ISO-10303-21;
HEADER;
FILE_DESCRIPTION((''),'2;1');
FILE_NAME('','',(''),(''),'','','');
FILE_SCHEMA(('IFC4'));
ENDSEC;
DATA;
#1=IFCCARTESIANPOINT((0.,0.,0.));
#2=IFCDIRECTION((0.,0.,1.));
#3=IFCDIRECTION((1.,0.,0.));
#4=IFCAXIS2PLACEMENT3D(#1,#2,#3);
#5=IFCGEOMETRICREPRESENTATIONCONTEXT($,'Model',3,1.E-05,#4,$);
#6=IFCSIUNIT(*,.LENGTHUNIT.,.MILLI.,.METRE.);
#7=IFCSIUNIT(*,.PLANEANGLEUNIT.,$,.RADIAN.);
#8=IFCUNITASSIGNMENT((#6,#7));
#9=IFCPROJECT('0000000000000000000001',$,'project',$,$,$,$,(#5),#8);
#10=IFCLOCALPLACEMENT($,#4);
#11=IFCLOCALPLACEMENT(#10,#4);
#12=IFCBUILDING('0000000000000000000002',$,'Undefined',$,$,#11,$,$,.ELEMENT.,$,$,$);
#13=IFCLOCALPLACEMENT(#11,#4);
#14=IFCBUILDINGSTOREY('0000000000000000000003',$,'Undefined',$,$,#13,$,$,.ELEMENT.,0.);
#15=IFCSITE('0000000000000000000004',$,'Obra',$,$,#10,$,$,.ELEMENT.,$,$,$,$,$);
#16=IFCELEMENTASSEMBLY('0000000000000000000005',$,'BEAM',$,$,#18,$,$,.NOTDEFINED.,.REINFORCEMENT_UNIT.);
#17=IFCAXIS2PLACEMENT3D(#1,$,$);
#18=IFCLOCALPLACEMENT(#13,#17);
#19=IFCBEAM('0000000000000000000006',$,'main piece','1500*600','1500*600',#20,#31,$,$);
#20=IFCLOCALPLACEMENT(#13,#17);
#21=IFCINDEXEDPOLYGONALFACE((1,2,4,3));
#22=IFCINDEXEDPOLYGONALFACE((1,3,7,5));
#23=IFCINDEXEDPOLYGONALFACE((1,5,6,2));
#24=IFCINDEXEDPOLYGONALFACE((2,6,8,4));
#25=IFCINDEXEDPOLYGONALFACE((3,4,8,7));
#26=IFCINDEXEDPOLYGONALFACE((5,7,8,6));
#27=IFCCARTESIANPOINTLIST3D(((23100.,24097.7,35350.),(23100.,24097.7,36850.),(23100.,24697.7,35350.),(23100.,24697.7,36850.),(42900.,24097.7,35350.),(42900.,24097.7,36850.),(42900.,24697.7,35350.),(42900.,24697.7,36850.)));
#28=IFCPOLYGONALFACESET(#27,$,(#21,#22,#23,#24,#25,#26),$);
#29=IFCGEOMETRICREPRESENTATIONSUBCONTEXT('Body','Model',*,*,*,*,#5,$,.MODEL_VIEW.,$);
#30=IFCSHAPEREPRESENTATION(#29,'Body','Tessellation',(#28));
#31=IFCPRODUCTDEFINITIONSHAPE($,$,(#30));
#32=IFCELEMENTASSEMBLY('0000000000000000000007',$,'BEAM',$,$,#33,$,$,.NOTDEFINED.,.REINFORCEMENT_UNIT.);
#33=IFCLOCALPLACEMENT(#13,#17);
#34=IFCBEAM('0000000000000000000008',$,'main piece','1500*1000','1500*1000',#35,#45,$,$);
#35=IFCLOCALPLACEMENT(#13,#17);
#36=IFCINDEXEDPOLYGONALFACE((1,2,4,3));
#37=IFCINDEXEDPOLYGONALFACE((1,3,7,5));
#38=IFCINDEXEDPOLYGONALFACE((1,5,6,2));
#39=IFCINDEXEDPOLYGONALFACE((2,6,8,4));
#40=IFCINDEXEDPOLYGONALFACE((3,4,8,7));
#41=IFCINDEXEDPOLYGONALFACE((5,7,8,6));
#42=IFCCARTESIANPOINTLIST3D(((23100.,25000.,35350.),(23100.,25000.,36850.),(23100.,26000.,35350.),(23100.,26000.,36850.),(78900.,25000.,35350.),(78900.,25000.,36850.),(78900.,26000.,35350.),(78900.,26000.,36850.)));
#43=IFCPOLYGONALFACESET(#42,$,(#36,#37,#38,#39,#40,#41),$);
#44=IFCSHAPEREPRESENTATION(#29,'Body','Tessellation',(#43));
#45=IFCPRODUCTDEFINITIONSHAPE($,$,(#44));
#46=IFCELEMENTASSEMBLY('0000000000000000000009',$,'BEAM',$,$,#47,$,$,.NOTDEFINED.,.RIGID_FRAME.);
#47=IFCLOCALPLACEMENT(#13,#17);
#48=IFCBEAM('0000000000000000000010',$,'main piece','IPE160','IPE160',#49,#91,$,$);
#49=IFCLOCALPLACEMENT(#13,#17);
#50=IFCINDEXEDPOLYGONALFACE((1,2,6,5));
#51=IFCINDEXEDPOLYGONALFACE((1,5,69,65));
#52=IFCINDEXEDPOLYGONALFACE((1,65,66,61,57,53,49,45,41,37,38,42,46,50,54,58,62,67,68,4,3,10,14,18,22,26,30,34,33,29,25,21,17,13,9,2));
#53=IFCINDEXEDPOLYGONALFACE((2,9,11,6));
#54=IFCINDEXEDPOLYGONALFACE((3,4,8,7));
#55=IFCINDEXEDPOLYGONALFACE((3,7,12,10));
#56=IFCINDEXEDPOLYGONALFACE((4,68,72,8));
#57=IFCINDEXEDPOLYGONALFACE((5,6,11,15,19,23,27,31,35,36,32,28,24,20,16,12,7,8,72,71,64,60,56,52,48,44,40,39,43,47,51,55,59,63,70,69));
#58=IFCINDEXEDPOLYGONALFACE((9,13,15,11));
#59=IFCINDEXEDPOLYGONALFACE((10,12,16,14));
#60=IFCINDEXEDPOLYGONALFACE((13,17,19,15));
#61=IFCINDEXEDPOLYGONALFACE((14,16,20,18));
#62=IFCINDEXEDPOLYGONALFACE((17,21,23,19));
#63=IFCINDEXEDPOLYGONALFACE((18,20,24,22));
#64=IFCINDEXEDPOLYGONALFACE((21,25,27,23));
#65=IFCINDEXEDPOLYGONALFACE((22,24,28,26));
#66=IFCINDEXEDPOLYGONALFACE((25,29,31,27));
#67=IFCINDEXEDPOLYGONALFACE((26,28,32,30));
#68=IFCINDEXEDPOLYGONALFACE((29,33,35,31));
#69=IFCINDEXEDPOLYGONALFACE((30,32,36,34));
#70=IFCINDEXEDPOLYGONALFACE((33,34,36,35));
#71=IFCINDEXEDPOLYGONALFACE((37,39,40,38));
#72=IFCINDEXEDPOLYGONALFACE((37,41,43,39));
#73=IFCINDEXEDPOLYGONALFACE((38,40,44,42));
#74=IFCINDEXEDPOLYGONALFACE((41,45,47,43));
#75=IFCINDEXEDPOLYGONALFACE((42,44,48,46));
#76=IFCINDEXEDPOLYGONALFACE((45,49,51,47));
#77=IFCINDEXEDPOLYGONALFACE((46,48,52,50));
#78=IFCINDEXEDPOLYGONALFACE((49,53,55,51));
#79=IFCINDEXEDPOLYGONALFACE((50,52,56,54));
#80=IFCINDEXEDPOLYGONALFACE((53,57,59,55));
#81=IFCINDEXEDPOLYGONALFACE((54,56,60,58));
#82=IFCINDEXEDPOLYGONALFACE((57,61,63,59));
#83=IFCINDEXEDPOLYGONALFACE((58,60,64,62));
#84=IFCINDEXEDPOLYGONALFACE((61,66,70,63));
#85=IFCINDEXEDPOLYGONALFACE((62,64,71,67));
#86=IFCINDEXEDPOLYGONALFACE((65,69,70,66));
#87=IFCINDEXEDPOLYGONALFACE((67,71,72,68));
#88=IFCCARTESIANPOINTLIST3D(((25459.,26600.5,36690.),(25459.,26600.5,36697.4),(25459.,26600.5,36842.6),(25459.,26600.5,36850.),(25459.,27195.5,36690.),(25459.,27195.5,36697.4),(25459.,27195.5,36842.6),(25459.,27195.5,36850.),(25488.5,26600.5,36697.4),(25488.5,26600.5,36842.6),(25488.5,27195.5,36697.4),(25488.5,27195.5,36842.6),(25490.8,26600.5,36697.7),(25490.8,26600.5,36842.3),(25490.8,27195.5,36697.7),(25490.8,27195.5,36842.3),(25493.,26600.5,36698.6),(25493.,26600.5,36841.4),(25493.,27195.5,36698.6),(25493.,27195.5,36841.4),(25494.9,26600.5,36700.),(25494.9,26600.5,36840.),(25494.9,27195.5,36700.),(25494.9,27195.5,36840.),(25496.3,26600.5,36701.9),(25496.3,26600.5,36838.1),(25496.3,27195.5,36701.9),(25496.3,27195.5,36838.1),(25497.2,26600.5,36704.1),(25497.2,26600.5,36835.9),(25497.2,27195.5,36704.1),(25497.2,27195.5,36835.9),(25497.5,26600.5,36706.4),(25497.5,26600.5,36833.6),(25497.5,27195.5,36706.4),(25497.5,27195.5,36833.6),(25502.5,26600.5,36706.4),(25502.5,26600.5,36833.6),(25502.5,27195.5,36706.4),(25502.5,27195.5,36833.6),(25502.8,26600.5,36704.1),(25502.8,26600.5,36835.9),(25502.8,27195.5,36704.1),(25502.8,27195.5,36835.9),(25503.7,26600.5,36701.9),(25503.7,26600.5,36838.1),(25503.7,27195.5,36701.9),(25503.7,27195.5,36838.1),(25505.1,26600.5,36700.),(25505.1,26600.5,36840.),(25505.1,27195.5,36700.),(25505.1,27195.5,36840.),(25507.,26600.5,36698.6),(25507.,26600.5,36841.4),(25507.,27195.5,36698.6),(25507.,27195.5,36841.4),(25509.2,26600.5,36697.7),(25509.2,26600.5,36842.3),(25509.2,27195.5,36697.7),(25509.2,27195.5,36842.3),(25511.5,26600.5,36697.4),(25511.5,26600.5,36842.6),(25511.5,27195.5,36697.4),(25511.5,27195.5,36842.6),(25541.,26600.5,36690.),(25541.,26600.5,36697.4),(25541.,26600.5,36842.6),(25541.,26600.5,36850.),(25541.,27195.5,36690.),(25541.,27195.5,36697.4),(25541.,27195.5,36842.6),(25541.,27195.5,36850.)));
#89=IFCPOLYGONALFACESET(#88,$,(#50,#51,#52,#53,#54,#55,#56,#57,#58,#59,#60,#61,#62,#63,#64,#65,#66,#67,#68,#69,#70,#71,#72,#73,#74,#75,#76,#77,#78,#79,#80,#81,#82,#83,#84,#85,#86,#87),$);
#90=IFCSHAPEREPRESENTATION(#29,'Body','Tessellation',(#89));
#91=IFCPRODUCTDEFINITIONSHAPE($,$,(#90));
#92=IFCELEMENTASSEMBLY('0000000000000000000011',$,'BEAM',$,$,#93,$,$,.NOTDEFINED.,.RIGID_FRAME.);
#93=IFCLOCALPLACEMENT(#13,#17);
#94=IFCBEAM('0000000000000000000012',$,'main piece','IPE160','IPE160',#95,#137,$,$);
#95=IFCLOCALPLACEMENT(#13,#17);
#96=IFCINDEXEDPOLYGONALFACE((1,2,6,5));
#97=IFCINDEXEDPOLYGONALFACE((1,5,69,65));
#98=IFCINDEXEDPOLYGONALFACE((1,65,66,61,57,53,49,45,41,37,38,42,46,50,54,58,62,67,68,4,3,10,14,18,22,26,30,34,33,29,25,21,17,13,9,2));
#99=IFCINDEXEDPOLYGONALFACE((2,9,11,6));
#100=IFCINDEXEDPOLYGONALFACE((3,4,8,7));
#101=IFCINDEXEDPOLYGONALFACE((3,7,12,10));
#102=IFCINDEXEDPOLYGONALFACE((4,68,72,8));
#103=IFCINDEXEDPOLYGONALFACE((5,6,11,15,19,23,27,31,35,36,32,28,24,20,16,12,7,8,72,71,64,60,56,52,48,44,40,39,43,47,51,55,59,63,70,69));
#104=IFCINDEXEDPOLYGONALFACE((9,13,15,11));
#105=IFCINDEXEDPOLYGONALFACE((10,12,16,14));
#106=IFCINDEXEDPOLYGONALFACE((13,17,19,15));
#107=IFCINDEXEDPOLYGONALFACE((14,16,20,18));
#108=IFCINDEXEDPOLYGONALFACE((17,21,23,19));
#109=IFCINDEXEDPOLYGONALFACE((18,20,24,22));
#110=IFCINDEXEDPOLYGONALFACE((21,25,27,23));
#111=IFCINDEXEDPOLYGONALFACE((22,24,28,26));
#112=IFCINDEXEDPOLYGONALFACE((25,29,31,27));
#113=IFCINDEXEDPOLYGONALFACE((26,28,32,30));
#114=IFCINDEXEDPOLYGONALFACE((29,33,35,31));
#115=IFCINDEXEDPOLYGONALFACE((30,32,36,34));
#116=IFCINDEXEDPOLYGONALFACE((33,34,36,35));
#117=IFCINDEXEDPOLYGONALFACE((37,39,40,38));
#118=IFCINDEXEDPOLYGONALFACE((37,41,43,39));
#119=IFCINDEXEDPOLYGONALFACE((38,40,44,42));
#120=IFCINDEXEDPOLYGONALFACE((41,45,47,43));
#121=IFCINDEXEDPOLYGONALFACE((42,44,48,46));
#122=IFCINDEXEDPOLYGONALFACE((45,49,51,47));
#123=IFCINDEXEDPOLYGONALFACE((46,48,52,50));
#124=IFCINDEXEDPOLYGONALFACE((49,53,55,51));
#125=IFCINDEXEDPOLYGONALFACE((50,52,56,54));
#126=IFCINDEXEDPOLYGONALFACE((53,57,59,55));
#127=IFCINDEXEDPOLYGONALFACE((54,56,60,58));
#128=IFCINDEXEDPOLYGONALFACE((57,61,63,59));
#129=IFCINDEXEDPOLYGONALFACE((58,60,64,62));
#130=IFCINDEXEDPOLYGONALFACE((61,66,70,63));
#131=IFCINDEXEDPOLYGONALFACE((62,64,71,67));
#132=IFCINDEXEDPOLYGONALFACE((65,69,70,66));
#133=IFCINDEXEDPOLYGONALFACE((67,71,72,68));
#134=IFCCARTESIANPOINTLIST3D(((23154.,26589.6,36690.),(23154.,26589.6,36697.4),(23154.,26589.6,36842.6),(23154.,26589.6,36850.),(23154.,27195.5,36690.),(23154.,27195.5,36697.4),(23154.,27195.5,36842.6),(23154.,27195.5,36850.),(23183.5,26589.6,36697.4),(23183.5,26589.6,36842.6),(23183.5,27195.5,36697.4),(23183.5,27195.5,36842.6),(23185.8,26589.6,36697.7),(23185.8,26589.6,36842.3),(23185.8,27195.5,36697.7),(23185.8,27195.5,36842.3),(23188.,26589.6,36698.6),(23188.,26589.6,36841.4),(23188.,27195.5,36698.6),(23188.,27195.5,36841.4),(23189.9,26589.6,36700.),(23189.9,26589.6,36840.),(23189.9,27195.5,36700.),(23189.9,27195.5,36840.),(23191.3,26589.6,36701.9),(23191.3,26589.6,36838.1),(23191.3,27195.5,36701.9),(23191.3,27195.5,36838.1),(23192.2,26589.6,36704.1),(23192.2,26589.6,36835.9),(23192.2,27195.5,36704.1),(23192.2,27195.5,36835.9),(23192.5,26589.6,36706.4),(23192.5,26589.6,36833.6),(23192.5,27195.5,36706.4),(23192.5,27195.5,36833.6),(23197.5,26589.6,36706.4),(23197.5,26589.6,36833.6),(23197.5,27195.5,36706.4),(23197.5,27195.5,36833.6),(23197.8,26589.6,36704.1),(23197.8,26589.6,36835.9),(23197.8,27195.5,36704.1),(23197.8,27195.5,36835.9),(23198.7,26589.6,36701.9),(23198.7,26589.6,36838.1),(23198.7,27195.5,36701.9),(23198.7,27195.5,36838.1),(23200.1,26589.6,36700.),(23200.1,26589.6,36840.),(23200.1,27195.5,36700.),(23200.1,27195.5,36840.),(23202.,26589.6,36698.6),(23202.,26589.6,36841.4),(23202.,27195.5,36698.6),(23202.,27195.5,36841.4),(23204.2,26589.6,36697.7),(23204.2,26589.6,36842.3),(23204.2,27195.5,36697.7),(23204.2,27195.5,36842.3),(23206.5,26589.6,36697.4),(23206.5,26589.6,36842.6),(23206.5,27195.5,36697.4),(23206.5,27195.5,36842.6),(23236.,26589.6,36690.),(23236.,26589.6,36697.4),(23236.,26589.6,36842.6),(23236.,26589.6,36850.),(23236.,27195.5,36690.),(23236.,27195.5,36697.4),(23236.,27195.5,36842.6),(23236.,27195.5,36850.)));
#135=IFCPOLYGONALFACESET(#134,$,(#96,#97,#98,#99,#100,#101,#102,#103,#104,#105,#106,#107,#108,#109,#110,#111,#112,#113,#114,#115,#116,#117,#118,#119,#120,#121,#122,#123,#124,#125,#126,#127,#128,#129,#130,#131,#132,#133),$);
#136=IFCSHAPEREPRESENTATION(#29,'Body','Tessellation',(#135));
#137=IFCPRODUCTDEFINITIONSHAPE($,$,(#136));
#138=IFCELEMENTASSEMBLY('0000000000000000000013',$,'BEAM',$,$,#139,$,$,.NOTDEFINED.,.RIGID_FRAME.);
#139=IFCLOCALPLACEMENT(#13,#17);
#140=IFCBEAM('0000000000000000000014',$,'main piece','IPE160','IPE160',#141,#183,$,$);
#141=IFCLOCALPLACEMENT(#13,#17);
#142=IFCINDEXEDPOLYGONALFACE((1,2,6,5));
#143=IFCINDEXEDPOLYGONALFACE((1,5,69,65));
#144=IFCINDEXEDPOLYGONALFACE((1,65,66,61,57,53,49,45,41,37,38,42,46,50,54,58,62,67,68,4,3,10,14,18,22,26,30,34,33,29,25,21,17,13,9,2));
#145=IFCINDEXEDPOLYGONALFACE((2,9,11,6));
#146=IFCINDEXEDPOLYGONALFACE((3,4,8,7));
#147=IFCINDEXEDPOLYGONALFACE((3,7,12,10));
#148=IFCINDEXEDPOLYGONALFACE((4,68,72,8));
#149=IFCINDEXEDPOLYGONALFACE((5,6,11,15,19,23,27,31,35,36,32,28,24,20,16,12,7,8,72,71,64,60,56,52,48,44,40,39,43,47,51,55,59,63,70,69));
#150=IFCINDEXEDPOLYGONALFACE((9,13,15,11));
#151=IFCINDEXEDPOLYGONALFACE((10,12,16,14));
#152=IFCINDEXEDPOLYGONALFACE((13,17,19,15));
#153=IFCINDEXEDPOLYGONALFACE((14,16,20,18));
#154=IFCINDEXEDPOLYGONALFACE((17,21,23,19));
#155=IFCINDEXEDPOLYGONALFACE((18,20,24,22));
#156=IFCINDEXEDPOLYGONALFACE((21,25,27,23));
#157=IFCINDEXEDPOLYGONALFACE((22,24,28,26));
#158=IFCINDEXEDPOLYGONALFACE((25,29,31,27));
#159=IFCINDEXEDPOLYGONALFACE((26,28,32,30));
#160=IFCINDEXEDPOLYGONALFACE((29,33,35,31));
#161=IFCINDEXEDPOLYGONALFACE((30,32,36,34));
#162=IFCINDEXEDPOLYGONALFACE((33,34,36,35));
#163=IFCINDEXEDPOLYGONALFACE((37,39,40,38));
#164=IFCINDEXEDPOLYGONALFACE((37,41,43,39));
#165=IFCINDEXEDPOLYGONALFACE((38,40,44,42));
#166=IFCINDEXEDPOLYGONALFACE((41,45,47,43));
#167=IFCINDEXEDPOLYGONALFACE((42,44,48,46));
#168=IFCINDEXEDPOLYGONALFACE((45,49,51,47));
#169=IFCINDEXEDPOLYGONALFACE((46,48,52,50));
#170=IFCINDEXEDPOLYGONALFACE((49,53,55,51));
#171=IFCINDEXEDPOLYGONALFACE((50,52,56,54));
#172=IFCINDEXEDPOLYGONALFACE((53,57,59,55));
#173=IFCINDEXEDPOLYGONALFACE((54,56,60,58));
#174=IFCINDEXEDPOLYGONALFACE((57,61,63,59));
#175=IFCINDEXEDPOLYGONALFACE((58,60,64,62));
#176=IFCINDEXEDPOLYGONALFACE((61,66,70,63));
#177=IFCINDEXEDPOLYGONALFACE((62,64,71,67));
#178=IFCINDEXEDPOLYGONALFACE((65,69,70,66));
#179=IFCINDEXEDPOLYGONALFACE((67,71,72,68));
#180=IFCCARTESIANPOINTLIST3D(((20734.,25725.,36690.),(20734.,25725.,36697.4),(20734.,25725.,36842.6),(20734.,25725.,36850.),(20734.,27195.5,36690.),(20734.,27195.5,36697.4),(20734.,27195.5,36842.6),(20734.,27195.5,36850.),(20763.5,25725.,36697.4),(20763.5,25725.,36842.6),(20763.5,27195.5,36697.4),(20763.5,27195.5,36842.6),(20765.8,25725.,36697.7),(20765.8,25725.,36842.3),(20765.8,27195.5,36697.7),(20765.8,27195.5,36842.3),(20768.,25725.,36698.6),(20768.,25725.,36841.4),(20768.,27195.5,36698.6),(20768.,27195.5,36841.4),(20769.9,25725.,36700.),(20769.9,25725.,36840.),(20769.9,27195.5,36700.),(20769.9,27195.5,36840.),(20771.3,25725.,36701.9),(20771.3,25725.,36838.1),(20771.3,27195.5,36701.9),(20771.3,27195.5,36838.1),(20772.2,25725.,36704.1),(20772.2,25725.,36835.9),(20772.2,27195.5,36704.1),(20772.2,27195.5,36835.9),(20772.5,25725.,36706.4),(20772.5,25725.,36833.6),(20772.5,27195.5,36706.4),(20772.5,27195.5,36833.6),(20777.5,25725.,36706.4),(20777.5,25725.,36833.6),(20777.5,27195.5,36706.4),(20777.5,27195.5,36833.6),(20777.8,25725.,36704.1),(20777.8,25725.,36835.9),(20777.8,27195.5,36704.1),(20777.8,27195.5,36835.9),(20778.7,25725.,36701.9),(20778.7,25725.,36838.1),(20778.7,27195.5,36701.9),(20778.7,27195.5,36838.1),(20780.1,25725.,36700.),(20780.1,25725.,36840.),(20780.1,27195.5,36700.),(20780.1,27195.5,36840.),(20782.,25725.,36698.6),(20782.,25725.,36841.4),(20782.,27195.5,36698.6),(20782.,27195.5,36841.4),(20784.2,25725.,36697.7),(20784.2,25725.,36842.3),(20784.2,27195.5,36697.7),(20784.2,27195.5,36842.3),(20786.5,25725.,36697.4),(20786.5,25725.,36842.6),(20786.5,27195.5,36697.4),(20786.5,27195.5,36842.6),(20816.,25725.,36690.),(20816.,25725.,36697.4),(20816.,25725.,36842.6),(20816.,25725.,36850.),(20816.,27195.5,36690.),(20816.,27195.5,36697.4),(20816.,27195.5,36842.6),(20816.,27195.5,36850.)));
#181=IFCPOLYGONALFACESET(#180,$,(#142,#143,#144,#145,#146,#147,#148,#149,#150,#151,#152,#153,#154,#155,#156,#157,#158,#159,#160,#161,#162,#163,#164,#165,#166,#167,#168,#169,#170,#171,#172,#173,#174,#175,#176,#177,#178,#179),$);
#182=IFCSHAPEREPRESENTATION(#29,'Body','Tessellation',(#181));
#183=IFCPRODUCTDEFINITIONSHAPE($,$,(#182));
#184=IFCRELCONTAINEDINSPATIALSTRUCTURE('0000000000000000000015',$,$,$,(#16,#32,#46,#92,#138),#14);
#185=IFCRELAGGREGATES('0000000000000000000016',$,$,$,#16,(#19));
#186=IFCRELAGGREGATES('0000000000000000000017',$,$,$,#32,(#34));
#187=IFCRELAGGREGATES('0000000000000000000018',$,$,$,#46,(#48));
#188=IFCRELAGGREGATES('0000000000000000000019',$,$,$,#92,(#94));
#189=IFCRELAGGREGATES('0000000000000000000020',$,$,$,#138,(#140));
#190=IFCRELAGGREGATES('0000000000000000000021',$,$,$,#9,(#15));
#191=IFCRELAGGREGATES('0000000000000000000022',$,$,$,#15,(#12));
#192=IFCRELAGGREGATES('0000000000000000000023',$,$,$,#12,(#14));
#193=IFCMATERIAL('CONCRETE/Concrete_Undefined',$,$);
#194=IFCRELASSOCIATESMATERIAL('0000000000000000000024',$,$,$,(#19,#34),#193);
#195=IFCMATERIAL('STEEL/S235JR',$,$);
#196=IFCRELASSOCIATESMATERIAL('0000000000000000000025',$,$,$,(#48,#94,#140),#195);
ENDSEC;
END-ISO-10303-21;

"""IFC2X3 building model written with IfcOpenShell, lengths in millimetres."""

from ifc_helpers import new_model, si_unit, frame, origin_with_axes, origin_2d_with_axis, place, context, subcontext, project, spatial, rectangle, i_section, extrude, material, element, aggregate, save


model = new_model("IFC2X3")

# Units and contexts
model_context = context("Model", 3, precision=1e-05, world=origin_with_axes())
body_context = subcontext(model_context, "Body", "Model", "MODEL_VIEW")
ifc_project = project(units=[si_unit("LENGTHUNIT", "METRE", prefix="MILLI"), si_unit("PLANEANGLEUNIT", "RADIAN")], contexts=[model_context])

# Site, building, storey
site_placement = place(None, origin_with_axes())
site = spatial("IfcSite", under=ifc_project, at=site_placement, Name="Obra", CompositionType="ELEMENT")
building_placement = place(site_placement, origin_with_axes())
building = spatial("IfcBuilding", under=site, at=building_placement, Name="Undefined", CompositionType="ELEMENT")
storey_placement = place(building_placement, origin_with_axes())
storey = spatial("IfcBuildingStorey", under=building, at=storey_placement, Name="Undefined", CompositionType="ELEMENT", Elevation=0.0)

# Element assemblies, beams
assembly_1_placement = place(storey_placement, origin_with_axes())
assembly_1 = element("IfcElementAssembly", 1, at=assembly_1_placement, inside=storey, Name="BEAM", AssemblyPlace="NOTDEFINED", PredefinedType="REINFORCEMENT_UNIT")
ifc_material_1 = material(Name="CONCRETE/Concrete_Undefined")
beam_1_placement = place(assembly_1_placement, frame((23100.0, 24397.7, 36100.0), z_axis=(0.0, 0.0, 1.0), x_axis=(1.0, 0.0, 0.0)))
beam_1 = element("IfcBeam", 2, at=beam_1_placement, material=ifc_material_1, Name="main piece", Description="1500*600", ObjectType="1500*600", context=body_context, shape_type="SweptSolid", body=[
    extrude(rectangle(XDim=600.0, YDim=1500.0, at=origin_2d_with_axis()), frame((19800.0, 0.0, 0.0), z_axis=(-1.0, 0.0, 0.0), x_axis=(0.0, -1.0, 0.0)), (0.0, 0.0, 1.0), 19800.0),
])
aggregate(assembly_1, [beam_1])
assembly_2_placement = place(storey_placement, origin_with_axes())
assembly_2 = element("IfcElementAssembly", 3, at=assembly_2_placement, inside=storey, Name="BEAM", AssemblyPlace="NOTDEFINED", PredefinedType="REINFORCEMENT_UNIT")
beam_2_placement = place(assembly_2_placement, frame((23100.0, 25500.0, 36100.0), z_axis=(0.0, 0.0, 1.0), x_axis=(1.0, 0.0, 0.0)))
beam_2 = element("IfcBeam", 4, at=beam_2_placement, material=ifc_material_1, Name="main piece", Description="1500*1000", ObjectType="1500*1000", context=body_context, shape_type="SweptSolid", body=[
    extrude(rectangle(XDim=1000.0, YDim=1500.0, at=origin_2d_with_axis()), frame((55800.0, 0.0, 0.0), z_axis=(-1.0, 0.0, 0.0), x_axis=(0.0, -1.0, 0.0)), (0.0, 0.0, 1.0), 55800.0),
])
aggregate(assembly_2, [beam_2])
assembly_3_placement = place(storey_placement, origin_with_axes())
assembly_3 = element("IfcElementAssembly", 5, at=assembly_3_placement, inside=storey, Name="BEAM", AssemblyPlace="NOTDEFINED", PredefinedType="RIGID_FRAME")
ifc_material_2 = material(Name="STEEL/S235JR")
beam_3_placement = place(assembly_3_placement, frame((25500.0, 26600.5, 36770.0), z_axis=(0.0, 0.0, 1.0), x_axis=(0.0, 1.0, 0.0)))
beam_3 = element("IfcBeam", 6, at=beam_3_placement, material=ifc_material_2, Name="main piece", Description="IPE160", ObjectType="IPE160", context=body_context, shape_type="SweptSolid", body=[
    extrude(i_section(OverallWidth=82.0, OverallDepth=160.0, WebThickness=5.0, FlangeThickness=7.4, FilletRadius=9.0, at=origin_2d_with_axis()), frame((595.0, 0.0, 0.0), z_axis=(-1.0, 0.0, 0.0), x_axis=(0.0, -1.0, 0.0)), (0.0, 0.0, 1.0), 595.0),
])
aggregate(assembly_3, [beam_3])
assembly_4_placement = place(storey_placement, origin_with_axes())
assembly_4 = element("IfcElementAssembly", 7, at=assembly_4_placement, inside=storey, Name="BEAM", AssemblyPlace="NOTDEFINED", PredefinedType="RIGID_FRAME")
beam_4_placement = place(assembly_4_placement, frame((23195.0, 26589.6, 36770.0), z_axis=(0.0, 0.0, 1.0), x_axis=(0.0, 1.0, 0.0)))
beam_4 = element("IfcBeam", 8, at=beam_4_placement, material=ifc_material_2, Name="main piece", Description="IPE160", ObjectType="IPE160", context=body_context, shape_type="SweptSolid", body=[
    extrude(i_section(OverallWidth=82.0, OverallDepth=160.0, WebThickness=5.0, FlangeThickness=7.4, FilletRadius=9.0, at=origin_2d_with_axis()), frame((605.9, 0.0, 0.0), z_axis=(-1.0, 0.0, 0.0), x_axis=(0.0, -1.0, 0.0)), (0.0, 0.0, 1.0), 605.9),
])
aggregate(assembly_4, [beam_4])
assembly_5_placement = place(storey_placement, origin_with_axes())
assembly_5 = element("IfcElementAssembly", 9, at=assembly_5_placement, inside=storey, Name="BEAM", AssemblyPlace="NOTDEFINED", PredefinedType="RIGID_FRAME")
beam_5_placement = place(assembly_5_placement, frame((20775.0, 25725.0, 36770.0), z_axis=(0.0, 0.0, 1.0), x_axis=(0.0, 1.0, 0.0)))
beam_5 = element("IfcBeam", 10, at=beam_5_placement, material=ifc_material_2, Name="main piece", Description="IPE160", ObjectType="IPE160", context=body_context, shape_type="SweptSolid", body=[
    extrude(i_section(OverallWidth=82.0, OverallDepth=160.0, WebThickness=5.0, FlangeThickness=7.4, FilletRadius=9.0, at=origin_2d_with_axis()), frame((1470.5, 0.0, 0.0), z_axis=(-1.0, 0.0, 0.0), x_axis=(0.0, -1.0, 0.0)), (0.0, 0.0, 1.0), 1470.5),
])
aggregate(assembly_5, [beam_5])

save(model, "model.ifc")
